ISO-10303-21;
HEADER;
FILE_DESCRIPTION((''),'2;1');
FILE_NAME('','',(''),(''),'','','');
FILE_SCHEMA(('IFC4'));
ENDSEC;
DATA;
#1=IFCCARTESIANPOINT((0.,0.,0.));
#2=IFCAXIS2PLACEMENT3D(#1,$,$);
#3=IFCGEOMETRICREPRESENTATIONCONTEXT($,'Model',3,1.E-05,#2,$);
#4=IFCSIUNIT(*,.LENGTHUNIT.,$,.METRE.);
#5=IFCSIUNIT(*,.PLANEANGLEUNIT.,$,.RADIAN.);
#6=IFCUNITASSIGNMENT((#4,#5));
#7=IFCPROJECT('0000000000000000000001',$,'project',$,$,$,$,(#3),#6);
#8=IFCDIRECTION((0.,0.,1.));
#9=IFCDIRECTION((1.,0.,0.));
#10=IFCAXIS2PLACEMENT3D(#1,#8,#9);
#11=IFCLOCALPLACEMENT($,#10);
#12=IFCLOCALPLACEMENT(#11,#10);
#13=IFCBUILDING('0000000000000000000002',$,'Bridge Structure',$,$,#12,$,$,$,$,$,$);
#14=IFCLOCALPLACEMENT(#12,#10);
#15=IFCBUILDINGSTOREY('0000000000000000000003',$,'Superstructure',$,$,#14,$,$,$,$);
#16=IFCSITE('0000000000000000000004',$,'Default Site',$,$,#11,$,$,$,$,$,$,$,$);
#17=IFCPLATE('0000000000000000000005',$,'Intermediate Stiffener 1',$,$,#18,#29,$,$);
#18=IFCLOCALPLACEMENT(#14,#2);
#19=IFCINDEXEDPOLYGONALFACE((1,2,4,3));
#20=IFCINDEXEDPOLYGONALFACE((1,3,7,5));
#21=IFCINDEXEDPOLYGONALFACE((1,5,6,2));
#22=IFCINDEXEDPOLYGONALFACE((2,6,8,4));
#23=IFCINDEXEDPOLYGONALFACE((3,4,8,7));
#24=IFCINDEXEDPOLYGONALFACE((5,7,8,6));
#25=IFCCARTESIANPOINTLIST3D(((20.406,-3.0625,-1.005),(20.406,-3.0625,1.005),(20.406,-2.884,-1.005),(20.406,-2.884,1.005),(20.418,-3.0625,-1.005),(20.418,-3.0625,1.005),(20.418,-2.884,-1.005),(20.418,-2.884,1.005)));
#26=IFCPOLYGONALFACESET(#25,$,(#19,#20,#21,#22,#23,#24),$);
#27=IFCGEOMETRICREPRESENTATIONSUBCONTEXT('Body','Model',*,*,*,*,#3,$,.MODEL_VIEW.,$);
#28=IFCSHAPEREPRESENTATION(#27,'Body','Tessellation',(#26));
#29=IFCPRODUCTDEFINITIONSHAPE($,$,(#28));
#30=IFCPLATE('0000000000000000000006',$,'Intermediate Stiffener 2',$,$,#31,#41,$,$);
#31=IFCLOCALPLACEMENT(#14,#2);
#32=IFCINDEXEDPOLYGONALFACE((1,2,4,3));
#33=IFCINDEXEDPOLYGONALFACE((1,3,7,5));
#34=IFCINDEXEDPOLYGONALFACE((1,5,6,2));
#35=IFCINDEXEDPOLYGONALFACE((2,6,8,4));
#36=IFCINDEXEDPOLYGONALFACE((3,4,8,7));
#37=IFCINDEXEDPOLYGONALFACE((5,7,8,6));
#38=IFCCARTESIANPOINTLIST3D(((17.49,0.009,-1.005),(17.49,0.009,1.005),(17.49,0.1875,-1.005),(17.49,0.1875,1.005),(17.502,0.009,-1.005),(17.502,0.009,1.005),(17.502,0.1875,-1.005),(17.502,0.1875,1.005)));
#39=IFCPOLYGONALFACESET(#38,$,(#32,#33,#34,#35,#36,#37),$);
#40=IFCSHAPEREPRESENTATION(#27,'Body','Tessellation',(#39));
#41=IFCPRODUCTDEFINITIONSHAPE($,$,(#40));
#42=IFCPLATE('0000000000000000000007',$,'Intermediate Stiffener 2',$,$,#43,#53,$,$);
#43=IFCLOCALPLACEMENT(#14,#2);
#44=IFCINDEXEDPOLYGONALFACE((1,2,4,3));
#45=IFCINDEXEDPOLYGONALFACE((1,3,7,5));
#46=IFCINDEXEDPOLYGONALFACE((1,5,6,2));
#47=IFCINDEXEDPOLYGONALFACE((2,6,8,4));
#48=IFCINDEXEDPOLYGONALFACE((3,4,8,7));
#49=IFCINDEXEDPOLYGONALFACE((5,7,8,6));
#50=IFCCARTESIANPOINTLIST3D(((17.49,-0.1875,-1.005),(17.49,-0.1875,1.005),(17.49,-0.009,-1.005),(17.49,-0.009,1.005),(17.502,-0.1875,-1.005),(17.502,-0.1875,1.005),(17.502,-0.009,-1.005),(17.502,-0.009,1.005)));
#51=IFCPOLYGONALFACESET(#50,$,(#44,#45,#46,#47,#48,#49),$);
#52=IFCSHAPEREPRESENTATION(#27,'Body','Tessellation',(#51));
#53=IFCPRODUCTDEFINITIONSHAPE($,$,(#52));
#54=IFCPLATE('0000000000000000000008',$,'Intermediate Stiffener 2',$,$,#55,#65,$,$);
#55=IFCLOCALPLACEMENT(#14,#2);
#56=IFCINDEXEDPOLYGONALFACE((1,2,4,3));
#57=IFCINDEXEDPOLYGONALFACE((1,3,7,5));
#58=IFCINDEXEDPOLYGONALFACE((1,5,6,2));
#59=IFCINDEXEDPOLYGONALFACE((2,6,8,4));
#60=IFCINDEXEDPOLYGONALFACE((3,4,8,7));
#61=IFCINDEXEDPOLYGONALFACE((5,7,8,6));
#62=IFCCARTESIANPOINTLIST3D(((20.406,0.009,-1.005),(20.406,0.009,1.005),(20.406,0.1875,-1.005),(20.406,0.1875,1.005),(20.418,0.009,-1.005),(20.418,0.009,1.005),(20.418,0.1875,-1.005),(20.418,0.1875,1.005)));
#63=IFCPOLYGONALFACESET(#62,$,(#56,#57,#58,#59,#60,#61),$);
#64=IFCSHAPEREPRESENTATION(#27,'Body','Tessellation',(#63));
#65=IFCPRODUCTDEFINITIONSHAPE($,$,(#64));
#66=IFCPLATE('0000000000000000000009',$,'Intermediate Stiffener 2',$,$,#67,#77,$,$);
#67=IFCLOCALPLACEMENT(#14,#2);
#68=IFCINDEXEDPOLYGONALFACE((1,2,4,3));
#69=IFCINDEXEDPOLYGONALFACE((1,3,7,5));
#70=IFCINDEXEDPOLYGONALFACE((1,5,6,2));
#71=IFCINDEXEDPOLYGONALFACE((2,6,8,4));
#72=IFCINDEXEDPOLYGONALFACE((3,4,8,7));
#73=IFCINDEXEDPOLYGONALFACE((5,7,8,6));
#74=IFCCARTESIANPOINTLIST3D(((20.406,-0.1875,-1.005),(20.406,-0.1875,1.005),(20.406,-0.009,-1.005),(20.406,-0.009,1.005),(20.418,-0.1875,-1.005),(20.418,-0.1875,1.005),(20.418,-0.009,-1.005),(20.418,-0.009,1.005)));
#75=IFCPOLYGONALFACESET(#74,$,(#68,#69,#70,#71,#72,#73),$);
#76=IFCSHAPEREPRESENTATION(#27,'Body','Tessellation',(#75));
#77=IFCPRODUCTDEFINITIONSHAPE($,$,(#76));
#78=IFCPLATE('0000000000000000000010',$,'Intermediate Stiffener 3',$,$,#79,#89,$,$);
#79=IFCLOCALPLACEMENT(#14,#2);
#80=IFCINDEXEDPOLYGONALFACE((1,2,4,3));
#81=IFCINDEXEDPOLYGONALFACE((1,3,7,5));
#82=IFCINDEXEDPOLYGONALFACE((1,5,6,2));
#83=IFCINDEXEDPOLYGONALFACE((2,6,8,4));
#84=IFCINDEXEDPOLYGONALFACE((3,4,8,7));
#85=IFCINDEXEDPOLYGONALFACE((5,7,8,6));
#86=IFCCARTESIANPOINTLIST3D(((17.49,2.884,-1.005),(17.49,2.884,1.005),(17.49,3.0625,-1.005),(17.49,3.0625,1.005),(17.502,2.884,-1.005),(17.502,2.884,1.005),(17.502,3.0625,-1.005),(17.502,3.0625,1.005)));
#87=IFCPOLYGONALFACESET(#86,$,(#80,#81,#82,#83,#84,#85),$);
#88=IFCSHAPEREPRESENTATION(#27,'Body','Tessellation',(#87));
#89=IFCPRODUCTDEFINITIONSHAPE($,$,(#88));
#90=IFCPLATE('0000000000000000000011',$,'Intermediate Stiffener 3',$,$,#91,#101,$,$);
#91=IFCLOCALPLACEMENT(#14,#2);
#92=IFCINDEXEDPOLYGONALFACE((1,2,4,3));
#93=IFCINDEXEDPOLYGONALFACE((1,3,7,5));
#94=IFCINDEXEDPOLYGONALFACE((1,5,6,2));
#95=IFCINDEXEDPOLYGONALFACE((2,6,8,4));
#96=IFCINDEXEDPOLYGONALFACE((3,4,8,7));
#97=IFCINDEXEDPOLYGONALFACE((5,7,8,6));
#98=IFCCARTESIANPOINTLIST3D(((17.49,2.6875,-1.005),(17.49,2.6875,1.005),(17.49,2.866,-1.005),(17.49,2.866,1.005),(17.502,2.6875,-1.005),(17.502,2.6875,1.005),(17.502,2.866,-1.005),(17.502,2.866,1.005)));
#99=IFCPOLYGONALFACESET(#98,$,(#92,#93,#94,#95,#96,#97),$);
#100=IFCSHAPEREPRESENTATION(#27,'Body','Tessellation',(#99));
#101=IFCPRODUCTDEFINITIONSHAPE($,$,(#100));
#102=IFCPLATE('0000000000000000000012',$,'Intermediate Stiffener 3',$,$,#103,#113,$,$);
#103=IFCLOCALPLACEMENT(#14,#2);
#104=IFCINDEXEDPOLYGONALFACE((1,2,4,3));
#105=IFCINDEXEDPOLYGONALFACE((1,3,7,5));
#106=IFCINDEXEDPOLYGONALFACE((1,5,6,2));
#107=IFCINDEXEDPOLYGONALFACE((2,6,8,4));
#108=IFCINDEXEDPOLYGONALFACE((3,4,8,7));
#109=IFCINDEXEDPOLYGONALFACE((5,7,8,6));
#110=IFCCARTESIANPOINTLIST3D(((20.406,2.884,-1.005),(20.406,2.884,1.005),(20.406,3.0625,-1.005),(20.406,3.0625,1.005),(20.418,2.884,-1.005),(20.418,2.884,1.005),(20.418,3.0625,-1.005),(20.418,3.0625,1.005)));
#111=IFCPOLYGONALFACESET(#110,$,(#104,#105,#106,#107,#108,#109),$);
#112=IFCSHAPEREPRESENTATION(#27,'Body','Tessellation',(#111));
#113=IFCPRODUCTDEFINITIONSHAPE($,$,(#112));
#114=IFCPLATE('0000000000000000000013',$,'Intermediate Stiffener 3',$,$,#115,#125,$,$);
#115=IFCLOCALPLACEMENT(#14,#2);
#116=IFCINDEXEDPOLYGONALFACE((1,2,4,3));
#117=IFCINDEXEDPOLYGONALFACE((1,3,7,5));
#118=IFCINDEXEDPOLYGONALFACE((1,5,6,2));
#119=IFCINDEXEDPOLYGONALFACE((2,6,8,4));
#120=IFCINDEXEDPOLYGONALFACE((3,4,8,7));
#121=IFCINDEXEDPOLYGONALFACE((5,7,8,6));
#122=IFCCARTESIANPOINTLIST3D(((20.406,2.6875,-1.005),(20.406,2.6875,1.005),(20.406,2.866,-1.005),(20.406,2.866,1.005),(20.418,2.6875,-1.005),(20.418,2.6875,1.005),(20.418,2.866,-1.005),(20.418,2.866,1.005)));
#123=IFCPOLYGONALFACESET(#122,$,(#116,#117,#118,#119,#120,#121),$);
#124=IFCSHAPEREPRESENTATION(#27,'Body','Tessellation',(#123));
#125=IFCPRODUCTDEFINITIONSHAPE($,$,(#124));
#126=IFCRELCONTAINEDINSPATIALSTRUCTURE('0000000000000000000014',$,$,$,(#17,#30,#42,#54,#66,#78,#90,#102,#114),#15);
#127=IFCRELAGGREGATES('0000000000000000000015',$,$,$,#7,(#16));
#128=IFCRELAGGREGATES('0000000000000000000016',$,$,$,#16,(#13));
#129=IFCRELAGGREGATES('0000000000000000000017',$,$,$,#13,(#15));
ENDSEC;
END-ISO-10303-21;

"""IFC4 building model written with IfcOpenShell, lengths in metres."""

from ifc_helpers import new_model, si_unit, frame, origin, origin_with_axes, origin_2d_with_axis, place, context, subcontext, project, spatial, rectangle, extrude, element, save


model = new_model("IFC4")

# Units and contexts
model_context = context("Model", 3, precision=1e-05, world=origin())
body_context = subcontext(model_context, "Body", "Model", "MODEL_VIEW")
ifc_project = project(units=[si_unit("LENGTHUNIT", "METRE"), si_unit("PLANEANGLEUNIT", "RADIAN")], contexts=[model_context])

# Site, building, storey
site_placement = place(None, origin_with_axes())
site = spatial("IfcSite", under=ifc_project, at=site_placement, Name="Default Site")
building_placement = place(site_placement, origin_with_axes())
building = spatial("IfcBuilding", under=site, at=building_placement, Name="Bridge Structure")
storey_placement = place(building_placement, origin_with_axes())
storey = spatial("IfcBuildingStorey", under=building, at=storey_placement, Name="Superstructure")

# Plates
for number, where, z_axis, x_axis, name in (
    (1, (20.412, -2.9733, -1.005), (0.0, 0.0, 1.0), (1.0, 0.0, 0.0), "Intermediate Stiffener 1"),
    (2, (17.496, 0.0983, -1.005), (0.0, 0.0, 1.0), (1.0, 0.0, 0.0), "Intermediate Stiffener 2"),
    (3, (17.496, -0.0983, -1.005), (0.0, 0.0, 1.0), (1.0, 0.0, 0.0), "Intermediate Stiffener 2"),
    (4, (20.412, 0.0983, -1.005), (0.0, 0.0, 1.0), (1.0, 0.0, 0.0), "Intermediate Stiffener 2"),
    (5, (20.412, -0.0983, -1.005), (0.0, 0.0, 1.0), (1.0, 0.0, 0.0), "Intermediate Stiffener 2"),
    (6, (17.496, 2.9733, -1.005), (0.0, 0.0, 1.0), (1.0, 0.0, 0.0), "Intermediate Stiffener 3"),
    (7, (17.496, 2.7768, -1.005), (0.0, 0.0, 1.0), (1.0, 0.0, 0.0), "Intermediate Stiffener 3"),
    (8, (20.412, 2.9733, -1.005), (0.0, 0.0, 1.0), (1.0, 0.0, 0.0), "Intermediate Stiffener 3"),
    (9, (20.412, 2.7768, -1.005), (0.0, 0.0, 1.0), (1.0, 0.0, 0.0), "Intermediate Stiffener 3"),
):
    element("IfcPlate", number, at=place(storey_placement, frame(where, z_axis=z_axis, x_axis=x_axis)), inside=storey, Name=name, context=body_context, shape_type="SweptSolid", body=[
        extrude(rectangle(XDim=0.012, YDim=0.1785, at=origin_2d_with_axis()), origin_with_axes(), (0.0, 0.0, 1.0), 2.01),
    ])

save(model, "model.ifc")
